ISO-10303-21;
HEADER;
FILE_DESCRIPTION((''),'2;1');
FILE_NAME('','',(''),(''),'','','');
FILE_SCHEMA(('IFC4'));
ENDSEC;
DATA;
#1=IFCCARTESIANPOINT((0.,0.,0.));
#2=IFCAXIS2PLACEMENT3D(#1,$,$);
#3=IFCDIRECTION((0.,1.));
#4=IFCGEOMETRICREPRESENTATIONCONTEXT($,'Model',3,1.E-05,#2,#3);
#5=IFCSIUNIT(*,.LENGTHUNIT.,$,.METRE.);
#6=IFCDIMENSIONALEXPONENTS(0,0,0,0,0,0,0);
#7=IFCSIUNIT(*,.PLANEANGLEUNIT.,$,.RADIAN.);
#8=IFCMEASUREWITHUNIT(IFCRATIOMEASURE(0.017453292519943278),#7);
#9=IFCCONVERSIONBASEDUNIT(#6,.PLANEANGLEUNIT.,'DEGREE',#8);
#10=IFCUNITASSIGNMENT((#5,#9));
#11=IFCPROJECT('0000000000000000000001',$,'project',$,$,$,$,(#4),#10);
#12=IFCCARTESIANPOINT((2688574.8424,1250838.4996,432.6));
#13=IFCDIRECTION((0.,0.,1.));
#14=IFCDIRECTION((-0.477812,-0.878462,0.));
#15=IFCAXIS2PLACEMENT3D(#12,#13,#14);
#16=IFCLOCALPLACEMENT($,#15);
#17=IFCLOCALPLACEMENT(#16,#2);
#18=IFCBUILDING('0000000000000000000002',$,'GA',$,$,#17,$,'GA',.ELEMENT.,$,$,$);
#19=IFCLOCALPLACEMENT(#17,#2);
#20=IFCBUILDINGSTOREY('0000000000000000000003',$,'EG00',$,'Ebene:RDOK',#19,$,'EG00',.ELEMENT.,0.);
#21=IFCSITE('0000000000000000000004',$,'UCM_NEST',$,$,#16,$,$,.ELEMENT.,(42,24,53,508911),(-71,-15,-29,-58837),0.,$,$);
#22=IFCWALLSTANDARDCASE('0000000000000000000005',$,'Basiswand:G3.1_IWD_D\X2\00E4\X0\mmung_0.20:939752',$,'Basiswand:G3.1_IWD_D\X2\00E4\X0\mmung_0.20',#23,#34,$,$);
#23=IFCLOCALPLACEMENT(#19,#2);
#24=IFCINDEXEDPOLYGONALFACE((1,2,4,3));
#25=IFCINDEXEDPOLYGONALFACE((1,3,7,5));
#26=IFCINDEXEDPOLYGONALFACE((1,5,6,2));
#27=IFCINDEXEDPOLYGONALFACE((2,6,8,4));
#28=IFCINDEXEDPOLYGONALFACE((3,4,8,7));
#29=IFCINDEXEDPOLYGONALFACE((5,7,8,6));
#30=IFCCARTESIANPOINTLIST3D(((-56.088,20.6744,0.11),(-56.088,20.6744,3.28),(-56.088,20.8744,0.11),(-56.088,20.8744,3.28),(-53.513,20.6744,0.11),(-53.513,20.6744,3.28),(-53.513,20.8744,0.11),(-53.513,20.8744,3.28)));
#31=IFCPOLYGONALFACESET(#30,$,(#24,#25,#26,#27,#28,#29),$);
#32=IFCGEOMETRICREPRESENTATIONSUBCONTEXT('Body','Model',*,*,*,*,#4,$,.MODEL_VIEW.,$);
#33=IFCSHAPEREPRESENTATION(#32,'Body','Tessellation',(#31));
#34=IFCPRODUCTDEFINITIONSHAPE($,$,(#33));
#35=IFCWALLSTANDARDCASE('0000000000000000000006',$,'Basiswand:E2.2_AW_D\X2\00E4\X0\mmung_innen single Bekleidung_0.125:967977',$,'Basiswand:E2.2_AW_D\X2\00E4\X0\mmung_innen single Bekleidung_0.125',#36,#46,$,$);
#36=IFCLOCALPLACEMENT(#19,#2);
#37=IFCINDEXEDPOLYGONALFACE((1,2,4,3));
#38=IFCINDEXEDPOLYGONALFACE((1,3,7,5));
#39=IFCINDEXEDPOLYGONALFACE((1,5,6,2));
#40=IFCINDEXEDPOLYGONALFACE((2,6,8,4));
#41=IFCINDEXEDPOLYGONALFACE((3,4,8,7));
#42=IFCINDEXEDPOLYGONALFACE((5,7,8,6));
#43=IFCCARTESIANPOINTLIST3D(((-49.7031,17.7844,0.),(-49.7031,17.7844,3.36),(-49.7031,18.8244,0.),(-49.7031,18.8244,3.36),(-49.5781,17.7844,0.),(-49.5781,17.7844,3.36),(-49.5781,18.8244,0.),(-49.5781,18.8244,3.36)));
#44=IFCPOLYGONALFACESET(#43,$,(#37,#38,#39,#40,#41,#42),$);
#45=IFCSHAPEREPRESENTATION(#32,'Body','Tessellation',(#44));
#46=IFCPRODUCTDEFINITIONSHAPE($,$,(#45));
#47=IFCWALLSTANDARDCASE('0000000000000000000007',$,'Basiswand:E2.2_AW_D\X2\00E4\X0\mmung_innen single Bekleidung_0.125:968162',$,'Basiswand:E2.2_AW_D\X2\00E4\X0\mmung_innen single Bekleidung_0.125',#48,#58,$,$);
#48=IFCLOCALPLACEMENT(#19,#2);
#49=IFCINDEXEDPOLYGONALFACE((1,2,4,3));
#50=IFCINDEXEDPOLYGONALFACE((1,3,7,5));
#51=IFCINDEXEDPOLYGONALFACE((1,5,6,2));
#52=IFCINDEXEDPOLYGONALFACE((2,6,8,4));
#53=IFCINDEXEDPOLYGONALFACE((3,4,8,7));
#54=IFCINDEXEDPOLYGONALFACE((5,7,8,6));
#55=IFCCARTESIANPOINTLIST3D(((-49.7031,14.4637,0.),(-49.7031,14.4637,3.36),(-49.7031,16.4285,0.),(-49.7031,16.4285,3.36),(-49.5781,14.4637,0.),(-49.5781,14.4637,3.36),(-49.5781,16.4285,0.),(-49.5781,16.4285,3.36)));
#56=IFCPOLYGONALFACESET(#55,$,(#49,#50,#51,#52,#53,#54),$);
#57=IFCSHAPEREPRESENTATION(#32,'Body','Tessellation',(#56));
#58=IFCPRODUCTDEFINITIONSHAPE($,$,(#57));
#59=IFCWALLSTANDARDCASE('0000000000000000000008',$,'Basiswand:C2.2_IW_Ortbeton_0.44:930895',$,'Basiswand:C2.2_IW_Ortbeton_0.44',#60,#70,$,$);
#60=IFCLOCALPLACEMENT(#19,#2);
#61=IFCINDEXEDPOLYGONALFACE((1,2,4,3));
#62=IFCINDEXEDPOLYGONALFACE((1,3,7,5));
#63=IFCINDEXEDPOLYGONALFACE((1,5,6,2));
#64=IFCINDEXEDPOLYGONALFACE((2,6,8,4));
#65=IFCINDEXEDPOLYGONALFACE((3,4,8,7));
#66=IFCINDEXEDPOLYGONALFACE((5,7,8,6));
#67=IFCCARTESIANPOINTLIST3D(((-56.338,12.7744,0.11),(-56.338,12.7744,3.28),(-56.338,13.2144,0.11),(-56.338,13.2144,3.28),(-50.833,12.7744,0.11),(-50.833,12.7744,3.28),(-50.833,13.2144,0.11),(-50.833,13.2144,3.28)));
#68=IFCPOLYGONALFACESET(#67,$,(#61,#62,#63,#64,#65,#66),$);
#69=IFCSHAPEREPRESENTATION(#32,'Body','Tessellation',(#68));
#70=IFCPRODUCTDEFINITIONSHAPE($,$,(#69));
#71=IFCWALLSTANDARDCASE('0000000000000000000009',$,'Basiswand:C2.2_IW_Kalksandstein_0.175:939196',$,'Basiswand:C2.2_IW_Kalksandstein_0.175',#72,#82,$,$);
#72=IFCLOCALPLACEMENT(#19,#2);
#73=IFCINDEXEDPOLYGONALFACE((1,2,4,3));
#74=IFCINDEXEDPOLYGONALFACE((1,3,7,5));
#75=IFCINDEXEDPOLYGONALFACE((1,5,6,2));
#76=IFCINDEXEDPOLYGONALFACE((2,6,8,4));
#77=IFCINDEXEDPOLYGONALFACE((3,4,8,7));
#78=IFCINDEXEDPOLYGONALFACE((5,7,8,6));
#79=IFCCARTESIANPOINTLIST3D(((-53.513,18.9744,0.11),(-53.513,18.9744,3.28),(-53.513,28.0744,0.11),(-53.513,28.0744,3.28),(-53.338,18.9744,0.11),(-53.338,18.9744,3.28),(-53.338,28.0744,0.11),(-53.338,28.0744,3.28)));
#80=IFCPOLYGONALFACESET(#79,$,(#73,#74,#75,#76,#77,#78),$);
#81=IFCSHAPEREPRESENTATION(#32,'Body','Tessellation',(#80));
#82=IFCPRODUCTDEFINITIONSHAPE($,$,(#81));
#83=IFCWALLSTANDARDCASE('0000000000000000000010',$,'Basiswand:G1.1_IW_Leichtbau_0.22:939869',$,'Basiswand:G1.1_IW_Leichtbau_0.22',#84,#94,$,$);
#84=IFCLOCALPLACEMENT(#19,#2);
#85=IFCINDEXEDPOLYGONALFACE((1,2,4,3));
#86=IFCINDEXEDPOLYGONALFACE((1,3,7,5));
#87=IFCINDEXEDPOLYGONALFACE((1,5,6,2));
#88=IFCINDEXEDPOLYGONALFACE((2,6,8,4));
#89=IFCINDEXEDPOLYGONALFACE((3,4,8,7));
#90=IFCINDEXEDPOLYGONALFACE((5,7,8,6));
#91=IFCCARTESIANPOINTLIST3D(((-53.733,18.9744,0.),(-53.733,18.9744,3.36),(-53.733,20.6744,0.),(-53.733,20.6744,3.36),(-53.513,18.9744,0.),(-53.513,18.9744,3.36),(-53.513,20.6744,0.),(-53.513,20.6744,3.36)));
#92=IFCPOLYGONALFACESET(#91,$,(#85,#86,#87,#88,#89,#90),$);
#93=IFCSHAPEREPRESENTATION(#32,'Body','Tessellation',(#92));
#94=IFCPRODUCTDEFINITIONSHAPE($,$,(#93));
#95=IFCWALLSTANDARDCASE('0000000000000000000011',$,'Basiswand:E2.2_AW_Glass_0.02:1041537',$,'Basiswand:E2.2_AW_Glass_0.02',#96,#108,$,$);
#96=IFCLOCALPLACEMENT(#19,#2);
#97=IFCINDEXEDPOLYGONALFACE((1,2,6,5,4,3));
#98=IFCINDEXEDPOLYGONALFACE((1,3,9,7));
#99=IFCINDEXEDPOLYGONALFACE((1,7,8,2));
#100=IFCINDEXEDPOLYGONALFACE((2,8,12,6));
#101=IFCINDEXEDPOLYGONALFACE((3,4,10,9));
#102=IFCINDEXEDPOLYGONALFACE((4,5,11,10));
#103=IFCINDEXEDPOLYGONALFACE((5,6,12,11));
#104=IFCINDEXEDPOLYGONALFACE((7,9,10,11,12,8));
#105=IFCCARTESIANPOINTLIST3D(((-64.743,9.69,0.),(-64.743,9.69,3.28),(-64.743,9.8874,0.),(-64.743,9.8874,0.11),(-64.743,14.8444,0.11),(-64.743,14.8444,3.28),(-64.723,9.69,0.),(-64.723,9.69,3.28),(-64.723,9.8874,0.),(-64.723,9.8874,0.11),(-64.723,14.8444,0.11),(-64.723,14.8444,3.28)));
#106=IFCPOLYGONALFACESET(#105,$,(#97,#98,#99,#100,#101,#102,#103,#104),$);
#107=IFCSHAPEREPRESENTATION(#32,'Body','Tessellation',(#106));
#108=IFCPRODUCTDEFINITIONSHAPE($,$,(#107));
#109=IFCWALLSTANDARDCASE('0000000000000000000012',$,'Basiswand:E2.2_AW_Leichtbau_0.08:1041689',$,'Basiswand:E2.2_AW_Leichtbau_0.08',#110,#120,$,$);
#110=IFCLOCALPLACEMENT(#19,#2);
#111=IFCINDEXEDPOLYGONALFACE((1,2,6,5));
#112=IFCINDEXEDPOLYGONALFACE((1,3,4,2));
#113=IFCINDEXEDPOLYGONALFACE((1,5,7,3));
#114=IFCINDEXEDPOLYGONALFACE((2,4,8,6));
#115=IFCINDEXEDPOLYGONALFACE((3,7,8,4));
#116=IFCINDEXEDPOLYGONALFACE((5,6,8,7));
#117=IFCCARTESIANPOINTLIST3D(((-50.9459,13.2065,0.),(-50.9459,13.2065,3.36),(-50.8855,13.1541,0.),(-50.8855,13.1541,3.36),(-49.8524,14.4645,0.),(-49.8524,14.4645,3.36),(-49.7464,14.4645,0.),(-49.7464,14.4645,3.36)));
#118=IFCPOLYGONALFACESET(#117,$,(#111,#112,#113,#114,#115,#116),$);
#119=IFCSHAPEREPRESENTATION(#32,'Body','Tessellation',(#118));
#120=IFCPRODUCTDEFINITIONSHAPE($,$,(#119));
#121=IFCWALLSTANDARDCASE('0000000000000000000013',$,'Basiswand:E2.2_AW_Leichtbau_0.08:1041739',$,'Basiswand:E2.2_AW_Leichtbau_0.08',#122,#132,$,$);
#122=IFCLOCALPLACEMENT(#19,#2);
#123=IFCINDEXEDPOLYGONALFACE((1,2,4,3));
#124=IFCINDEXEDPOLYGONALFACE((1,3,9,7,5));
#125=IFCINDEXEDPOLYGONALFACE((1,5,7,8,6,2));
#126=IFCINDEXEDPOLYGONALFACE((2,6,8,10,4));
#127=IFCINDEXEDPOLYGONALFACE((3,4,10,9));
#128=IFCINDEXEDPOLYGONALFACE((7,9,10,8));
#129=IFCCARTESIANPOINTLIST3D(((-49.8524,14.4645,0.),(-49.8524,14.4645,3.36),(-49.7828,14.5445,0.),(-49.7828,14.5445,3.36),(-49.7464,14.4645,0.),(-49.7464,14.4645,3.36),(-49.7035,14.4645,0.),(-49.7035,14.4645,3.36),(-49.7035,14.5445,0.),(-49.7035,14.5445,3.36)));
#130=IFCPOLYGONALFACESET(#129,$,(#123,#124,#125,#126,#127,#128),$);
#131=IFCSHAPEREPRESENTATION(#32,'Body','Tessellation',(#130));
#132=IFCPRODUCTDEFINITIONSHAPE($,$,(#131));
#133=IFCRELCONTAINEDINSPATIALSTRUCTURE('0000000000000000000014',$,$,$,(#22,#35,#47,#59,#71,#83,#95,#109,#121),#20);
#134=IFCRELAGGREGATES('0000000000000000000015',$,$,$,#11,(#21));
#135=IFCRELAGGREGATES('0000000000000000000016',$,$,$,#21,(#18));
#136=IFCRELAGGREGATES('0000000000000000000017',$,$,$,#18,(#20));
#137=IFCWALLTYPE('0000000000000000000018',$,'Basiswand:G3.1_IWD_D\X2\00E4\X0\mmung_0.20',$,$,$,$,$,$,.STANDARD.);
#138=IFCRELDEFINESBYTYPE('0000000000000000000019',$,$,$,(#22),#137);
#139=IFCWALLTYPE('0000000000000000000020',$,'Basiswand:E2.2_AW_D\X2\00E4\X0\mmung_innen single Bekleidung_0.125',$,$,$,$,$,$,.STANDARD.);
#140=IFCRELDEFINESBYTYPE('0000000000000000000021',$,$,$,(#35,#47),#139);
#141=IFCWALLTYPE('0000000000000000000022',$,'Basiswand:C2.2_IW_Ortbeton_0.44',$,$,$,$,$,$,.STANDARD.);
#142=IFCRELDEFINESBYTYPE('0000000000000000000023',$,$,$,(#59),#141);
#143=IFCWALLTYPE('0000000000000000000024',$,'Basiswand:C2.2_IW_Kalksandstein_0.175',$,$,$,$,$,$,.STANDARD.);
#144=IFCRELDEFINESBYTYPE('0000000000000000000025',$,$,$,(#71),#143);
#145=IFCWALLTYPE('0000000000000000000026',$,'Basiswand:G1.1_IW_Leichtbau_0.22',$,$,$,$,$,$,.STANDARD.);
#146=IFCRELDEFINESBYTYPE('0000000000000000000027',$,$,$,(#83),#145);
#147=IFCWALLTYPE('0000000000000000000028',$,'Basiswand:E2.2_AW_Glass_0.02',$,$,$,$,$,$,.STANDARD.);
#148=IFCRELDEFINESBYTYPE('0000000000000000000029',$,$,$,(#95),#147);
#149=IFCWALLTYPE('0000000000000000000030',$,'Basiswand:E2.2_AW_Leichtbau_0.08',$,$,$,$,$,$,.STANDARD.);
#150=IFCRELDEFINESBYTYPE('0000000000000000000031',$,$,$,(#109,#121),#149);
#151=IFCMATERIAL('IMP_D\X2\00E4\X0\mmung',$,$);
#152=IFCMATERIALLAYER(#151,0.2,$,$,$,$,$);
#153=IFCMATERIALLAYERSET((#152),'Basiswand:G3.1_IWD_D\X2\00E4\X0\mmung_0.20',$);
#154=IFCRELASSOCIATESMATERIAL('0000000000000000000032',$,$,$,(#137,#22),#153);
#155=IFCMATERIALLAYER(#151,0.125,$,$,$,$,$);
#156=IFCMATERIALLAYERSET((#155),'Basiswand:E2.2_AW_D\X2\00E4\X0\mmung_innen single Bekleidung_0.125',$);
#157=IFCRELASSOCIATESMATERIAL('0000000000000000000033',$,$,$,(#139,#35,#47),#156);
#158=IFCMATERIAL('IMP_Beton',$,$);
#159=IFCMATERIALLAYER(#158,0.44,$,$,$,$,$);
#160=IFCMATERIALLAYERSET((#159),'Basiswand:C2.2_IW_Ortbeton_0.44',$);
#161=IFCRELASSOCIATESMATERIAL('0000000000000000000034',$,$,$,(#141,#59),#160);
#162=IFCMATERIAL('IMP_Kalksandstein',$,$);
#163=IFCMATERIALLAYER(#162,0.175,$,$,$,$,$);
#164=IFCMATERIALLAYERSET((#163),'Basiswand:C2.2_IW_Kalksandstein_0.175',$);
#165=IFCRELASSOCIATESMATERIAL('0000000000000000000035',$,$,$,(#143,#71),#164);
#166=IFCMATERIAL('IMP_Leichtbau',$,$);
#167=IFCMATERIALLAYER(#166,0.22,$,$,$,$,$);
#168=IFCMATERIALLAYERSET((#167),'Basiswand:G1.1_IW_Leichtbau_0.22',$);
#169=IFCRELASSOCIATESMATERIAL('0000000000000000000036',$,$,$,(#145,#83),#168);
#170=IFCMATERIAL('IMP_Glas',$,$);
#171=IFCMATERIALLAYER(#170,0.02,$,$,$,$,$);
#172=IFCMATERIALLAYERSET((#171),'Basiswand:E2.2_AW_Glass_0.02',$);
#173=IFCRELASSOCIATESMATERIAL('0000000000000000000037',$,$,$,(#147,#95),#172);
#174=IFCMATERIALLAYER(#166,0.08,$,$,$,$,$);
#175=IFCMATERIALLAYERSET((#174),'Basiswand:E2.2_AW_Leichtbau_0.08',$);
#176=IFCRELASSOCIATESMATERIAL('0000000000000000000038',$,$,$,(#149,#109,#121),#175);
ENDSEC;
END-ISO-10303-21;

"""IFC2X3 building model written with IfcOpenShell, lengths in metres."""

from ifc_helpers import new_model, entity, si_unit, converted_unit, direction, frame, frame_2d, origin, place, context, subcontext, project, spatial, polyline, rectangle, outline, extrude, clip, bounded_halfspace, material, layer, layer_set, layer_usage, type_object, element, save


model = new_model("IFC2X3")

# Units and contexts
model_context = context("Model", 3, precision=1e-05, world=origin(), true_north=direction((0.0, 1.0)))
body_context = subcontext(model_context, "Body", "Model", "MODEL_VIEW")
ifc_project = project(units=[si_unit("LENGTHUNIT", "METRE"), converted_unit("PLANEANGLEUNIT", "DEGREE", entity("IfcRatioMeasure", 0.017453292519943278), si_unit("PLANEANGLEUNIT", "RADIAN"), dimensions=[0, 0, 0, 0, 0, 0, 0])], contexts=[model_context])

# Site, building, storey
site_placement = place(None, frame((2688574.8424, 1250838.4996, 432.6), z_axis=(0.0, 0.0, 1.0), x_axis=(-0.477812, -0.878462, 0.0)))
site = spatial("IfcSite", under=ifc_project, at=site_placement, Name="UCM_NEST", CompositionType="ELEMENT", RefLatitude=(42, 24, 53, 508911), RefLongitude=(-71, -15, -29, -58837), RefElevation=0.0)
building_placement = place(site_placement, origin())
building = spatial("IfcBuilding", under=site, at=building_placement, Name="GA", LongName="GA", CompositionType="ELEMENT")
storey_placement = place(building_placement, origin())
storey = spatial("IfcBuildingStorey", under=building, at=storey_placement, Name="EG00", ObjectType="Ebene:RDOK", LongName="EG00", CompositionType="ELEMENT", Elevation=0.0)

# Shared definitions
ifc_material_1 = material(Name="IMP_Beton")

# Shared definitions
ifc_material_2 = material(Name="IMP_Glas")

# Shared definitions
ifc_material_3 = material(Name="IMP_Dämmung")

# Walls
ifc_layer_1 = layer(ifc_material_3, 0.2)
ifc_layer_set_1 = layer_set([ifc_layer_1], Name="Basiswand:G3.1_IWD_Dämmung_0.20")
ifc_layer_usage_1 = layer_usage(ifc_layer_set_1, "AXIS2", "NEGATIVE", 0.1)
wall_type_1 = type_object("IfcWallType", Name="Basiswand:G3.1_IWD_Dämmung_0.20", PredefinedType="STANDARD", material=ifc_layer_set_1)
wall_1_placement = place(storey_placement, frame((-53.513, 20.7744, 0.11), z_axis=(0.0, 0.0, 1.0), x_axis=(-1.0, 0.0, 0.0)))
element("IfcWallStandardCase", 1, at=wall_1_placement, inside=storey, type_object=wall_type_1, material=ifc_layer_usage_1, Name="Basiswand:G3.1_IWD_Dämmung_0.20:939752", ObjectType="Basiswand:G3.1_IWD_Dämmung_0.20", context=body_context, shape_type="Clipping", body=[
    clip(extrude(rectangle(XDim=2.575, YDim=0.2, at=frame_2d((1.2875, 0.0), x_axis=(-1.0, 0.0))), origin(), (0.0, 0.0, 1.0), 3.17), bounded_halfspace(frame((2.575, -0.1, 0.0)), True, frame((2.575, -0.1, 0.0)), polyline([(0.0, 0.0), (0.0, 0.2), (-2.575, 0.2), (-2.575, 0.0), (0.0, 0.0)]))),
])
ifc_layer_2 = layer(ifc_material_3, 0.125)
ifc_layer_set_2 = layer_set([ifc_layer_2], Name="Basiswand:E2.2_AW_Dämmung_innen single Bekleidung_0.125")
ifc_layer_usage_2 = layer_usage(ifc_layer_set_2, "AXIS2", "NEGATIVE", 0.0625)
wall_type_2 = type_object("IfcWallType", Name="Basiswand:E2.2_AW_Dämmung_innen single Bekleidung_0.125", PredefinedType="STANDARD", material=ifc_layer_set_2)
wall_2_placement = place(storey_placement, frame((-49.6406, 18.8244, 0.0), z_axis=(0.0, 0.0, 1.0), x_axis=(0.0, -1.0, 0.0)))
element("IfcWallStandardCase", 2, at=wall_2_placement, inside=storey, type_object=wall_type_2, material=ifc_layer_usage_2, Name="Basiswand:E2.2_AW_Dämmung_innen single Bekleidung_0.125:967977", ObjectType="Basiswand:E2.2_AW_Dämmung_innen single Bekleidung_0.125", context=body_context, shape_type="SweptSolid", body=[
    extrude(rectangle(XDim=1.04, YDim=0.125, at=frame_2d((0.52, 0.0), x_axis=(-1.0, 0.0))), origin(), (0.0, 0.0, 1.0), 3.36),
])
wall_3_placement = place(storey_placement, frame((-49.6406, 16.4285, 0.0), z_axis=(0.0, 0.0, 1.0), x_axis=(0.0, -1.0, 0.0)))
element("IfcWallStandardCase", 3, at=wall_3_placement, inside=storey, type_object=wall_type_2, material=ifc_layer_usage_2, Name="Basiswand:E2.2_AW_Dämmung_innen single Bekleidung_0.125:968162", ObjectType="Basiswand:E2.2_AW_Dämmung_innen single Bekleidung_0.125", context=body_context, shape_type="SweptSolid", body=[
    extrude(rectangle(XDim=1.9648, YDim=0.125, at=frame_2d((0.9824, 0.0), x_axis=(-1.0, 0.0))), origin(), (0.0, 0.0, 1.0), 3.36),
])
ifc_layer_3 = layer(ifc_material_1, 0.44)
ifc_layer_set_3 = layer_set([ifc_layer_3], Name="Basiswand:C2.2_IW_Ortbeton_0.44")
ifc_layer_usage_3 = layer_usage(ifc_layer_set_3, "AXIS2", "NEGATIVE", 0.22)
wall_type_3 = type_object("IfcWallType", Name="Basiswand:C2.2_IW_Ortbeton_0.44", PredefinedType="STANDARD", material=ifc_layer_set_3)
wall_4_placement = place(storey_placement, frame((-50.833, 12.9944, 0.11), z_axis=(0.0, 0.0, 1.0), x_axis=(-1.0, 0.0, 0.0)))
element("IfcWallStandardCase", 4, at=wall_4_placement, inside=storey, type_object=wall_type_3, material=ifc_layer_usage_3, Name="Basiswand:C2.2_IW_Ortbeton_0.44:930895", ObjectType="Basiswand:C2.2_IW_Ortbeton_0.44", context=body_context, shape_type="Clipping", body=[
    clip(clip(extrude(rectangle(XDim=5.505, YDim=0.44, at=frame_2d((2.7525, 0.0), x_axis=(-1.0, 0.0))), origin(), (0.0, 0.0, 1.0), 3.17), bounded_halfspace(frame((5.505, -0.22, 0.0)), True, frame((5.505, -0.22, 0.0)), polyline([(0.0, 0.0), (0.0, 0.44), (-5.505, 0.44), (-5.505, 0.0), (-0.25, 0.0), (0.0, 0.0)]))), bounded_halfspace(frame((0.0, -0.22, 3.17), z_axis=(0.0, 0.0, -1.0), x_axis=(1.0, 0.0, 0.0)), True, frame((0.0, -0.22, 3.17), z_axis=(0.0, 0.0, -1.0), x_axis=(1.0, 0.0, 0.0)), polyline([(0.0, 0.0), (0.0, -0.44), (5.505, -0.44), (5.505, 0.0), (0.0, 0.0)]))),
])
ifc_material_4 = material(Name="IMP_Kalksandstein")
ifc_layer_4 = layer(ifc_material_4, 0.175)
ifc_layer_set_4 = layer_set([ifc_layer_4], Name="Basiswand:C2.2_IW_Kalksandstein_0.175")
ifc_layer_usage_4 = layer_usage(ifc_layer_set_4, "AXIS2", "NEGATIVE", 0.0875)
wall_type_4 = type_object("IfcWallType", Name="Basiswand:C2.2_IW_Kalksandstein_0.175", PredefinedType="STANDARD", material=ifc_layer_set_4)
wall_5_placement = place(storey_placement, frame((-53.4255, 18.9744, 0.11), z_axis=(0.0, 0.0, 1.0), x_axis=(0.0, 1.0, 0.0)))
element("IfcWallStandardCase", 5, at=wall_5_placement, inside=storey, type_object=wall_type_4, material=ifc_layer_usage_4, Name="Basiswand:C2.2_IW_Kalksandstein_0.175:939196", ObjectType="Basiswand:C2.2_IW_Kalksandstein_0.175", context=body_context, shape_type="Clipping", body=[
    clip(clip(extrude(rectangle(XDim=9.1, YDim=0.175, at=frame_2d((4.55, 0.0), x_axis=(-1.0, 0.0))), origin(), (0.0, 0.0, 1.0), 3.17), bounded_halfspace(frame((9.1, -0.0875, 0.0), z_axis=(0.0, 0.0, 1.0), x_axis=(0.0, 1.0, 0.0)), True, frame((9.1, -0.0875, 0.0), z_axis=(0.0, 0.0, 1.0), x_axis=(0.0, 1.0, 0.0)), polyline([(0.0, 0.0), (0.175, 0.0), (0.175, 7.2), (0.175, 7.4), (0.175, 9.1), (0.0, 9.1), (0.0, 0.0)]))), bounded_halfspace(frame((0.0, -0.0875, 3.17), z_axis=(0.0, 0.0, -1.0), x_axis=(0.0, 1.0, 0.0)), True, frame((0.0, -0.0875, 3.17), z_axis=(0.0, 0.0, -1.0), x_axis=(0.0, 1.0, 0.0)), polyline([(0.0, 0.0), (0.175, 0.0), (0.175, 1.7), (0.175, 1.9), (0.175, 9.1), (0.0, 9.1), (0.0, 0.0)]))),
])
ifc_material_5 = material(Name="IMP_Leichtbau")
ifc_layer_5 = layer(ifc_material_5, 0.22)
ifc_layer_set_5 = layer_set([ifc_layer_5], Name="Basiswand:G1.1_IW_Leichtbau_0.22")
ifc_layer_usage_5 = layer_usage(ifc_layer_set_5, "AXIS2", "NEGATIVE", 0.11)
wall_type_5 = type_object("IfcWallType", Name="Basiswand:G1.1_IW_Leichtbau_0.22", PredefinedType="STANDARD", material=ifc_layer_set_5)
wall_6_placement = place(storey_placement, frame((-53.623, 20.6744, 0.0), z_axis=(0.0, 0.0, 1.0), x_axis=(0.0, -1.0, 0.0)))
element("IfcWallStandardCase", 6, at=wall_6_placement, inside=storey, type_object=wall_type_5, material=ifc_layer_usage_5, Name="Basiswand:G1.1_IW_Leichtbau_0.22:939869", ObjectType="Basiswand:G1.1_IW_Leichtbau_0.22", context=body_context, shape_type="SweptSolid", body=[
    extrude(rectangle(XDim=1.7, YDim=0.22, at=frame_2d((0.85, 0.0), x_axis=(-1.0, 0.0))), origin(), (0.0, 0.0, 1.0), 3.36),
])

# Walls
ifc_layer_6 = layer(ifc_material_2, 0.02)
ifc_layer_set_6 = layer_set([ifc_layer_6], Name="Basiswand:E2.2_AW_Glass_0.02")
ifc_layer_usage_6 = layer_usage(ifc_layer_set_6, "AXIS2", "NEGATIVE", 0.01)
wall_type_6 = type_object("IfcWallType", Name="Basiswand:E2.2_AW_Glass_0.02", PredefinedType="STANDARD", material=ifc_layer_set_6)
wall_7_placement = place(storey_placement, frame((-64.733, 14.8444, 0.0), z_axis=(0.0, 0.0, 1.0), x_axis=(0.0, -1.0, 0.0)))
element("IfcWallStandardCase", 7, at=wall_7_placement, inside=storey, type_object=wall_type_6, material=ifc_layer_usage_6, Name="Basiswand:E2.2_AW_Glass_0.02:1041537", ObjectType="Basiswand:E2.2_AW_Glass_0.02", context=body_context, shape_type="Clipping", body=[
    clip(clip(clip(extrude(rectangle(XDim=5.1545, YDim=0.02, at=frame_2d((2.5772, 0.0), x_axis=(-1.0, 0.0))), origin(), (0.0, 0.0, 1.0), 3.28), bounded_halfspace(frame((4.957, 0.01, 0.11), z_axis=(0.0, 0.0, 1.0), x_axis=(0.0, -1.0, 0.0)), True, frame((4.957, 0.01, 0.11), z_axis=(0.0, 0.0, 1.0), x_axis=(0.0, -1.0, 0.0)), polyline([(0.0, 0.0), (0.0, -4.957), (0.02, -4.957), (0.02, 0.0), (0.0, 0.0)]))), bounded_halfspace(frame((4.957, -0.01, 0.11), z_axis=(1.0, 0.0, 0.0), x_axis=(0.0, 0.0, 1.0)), True, frame((4.957, -0.01, 0.11), z_axis=(1.0, 0.0, 0.0), x_axis=(0.0, 0.0, 1.0)), polyline([(0.0, 0.0), (-0.11, 0.0), (-0.11, -0.02), (0.0, -0.02), (0.0, 0.0)]))), bounded_halfspace(frame((0.0, -0.01, 3.28), z_axis=(0.0, 0.0, -1.0), x_axis=(0.0, -1.0, 0.0)), True, frame((0.0, -0.01, 3.28), z_axis=(0.0, 0.0, -1.0), x_axis=(0.0, -1.0, 0.0)), polyline([(0.0, 0.0), (-0.02, 0.0), (-0.02, -5.1545), (0.0, -5.1545), (0.0, 0.0)]))),
])
ifc_layer_7 = layer(ifc_material_5, 0.08)
ifc_layer_set_7 = layer_set([ifc_layer_7], Name="Basiswand:E2.2_AW_Leichtbau_0.08")
ifc_layer_usage_7 = layer_usage(ifc_layer_set_7, "AXIS2", "NEGATIVE", 0.04)
wall_type_7 = type_object("IfcWallType", Name="Basiswand:E2.2_AW_Leichtbau_0.08", PredefinedType="STANDARD", material=ifc_layer_set_7)
wall_8_placement = place(storey_placement, frame((-50.9157, 13.1803, 0.0), z_axis=(0.0, 0.0, 1.0), x_axis=(0.656059, 0.75471, 0.0)))
element("IfcWallStandardCase", 8, at=wall_8_placement, inside=storey, type_object=wall_type_7, material=ifc_layer_usage_7, Name="Basiswand:E2.2_AW_Leichtbau_0.08:1041689", ObjectType="Basiswand:E2.2_AW_Leichtbau_0.08", context=body_context, shape_type="SweptSolid", body=[
    extrude(outline(polyline([(1.7363, -0.04), (1.6667, 0.04), (0.0, 0.04), (0.0, -0.04), (1.7363, -0.04)])), origin(), (0.0, 0.0, 1.0), 3.36),
])
wall_9_placement = place(storey_placement, frame((-49.7035, 14.5045, 0.0), z_axis=(0.0, 0.0, 1.0), x_axis=(-1.0, 0.0, 0.0)))
element("IfcWallStandardCase", 9, at=wall_9_placement, inside=storey, type_object=wall_type_7, material=ifc_layer_usage_7, Name="Basiswand:E2.2_AW_Leichtbau_0.08:1041739", ObjectType="Basiswand:E2.2_AW_Leichtbau_0.08", context=body_context, shape_type="SweptSolid", body=[
    extrude(outline(polyline([(0.0793, -0.04), (0.1489, 0.04), (0.0429, 0.04), (0.0, 0.04), (0.0, -0.04), (0.0793, -0.04)])), origin(), (0.0, 0.0, 1.0), 3.36),
])

save(model, "model.ifc")
